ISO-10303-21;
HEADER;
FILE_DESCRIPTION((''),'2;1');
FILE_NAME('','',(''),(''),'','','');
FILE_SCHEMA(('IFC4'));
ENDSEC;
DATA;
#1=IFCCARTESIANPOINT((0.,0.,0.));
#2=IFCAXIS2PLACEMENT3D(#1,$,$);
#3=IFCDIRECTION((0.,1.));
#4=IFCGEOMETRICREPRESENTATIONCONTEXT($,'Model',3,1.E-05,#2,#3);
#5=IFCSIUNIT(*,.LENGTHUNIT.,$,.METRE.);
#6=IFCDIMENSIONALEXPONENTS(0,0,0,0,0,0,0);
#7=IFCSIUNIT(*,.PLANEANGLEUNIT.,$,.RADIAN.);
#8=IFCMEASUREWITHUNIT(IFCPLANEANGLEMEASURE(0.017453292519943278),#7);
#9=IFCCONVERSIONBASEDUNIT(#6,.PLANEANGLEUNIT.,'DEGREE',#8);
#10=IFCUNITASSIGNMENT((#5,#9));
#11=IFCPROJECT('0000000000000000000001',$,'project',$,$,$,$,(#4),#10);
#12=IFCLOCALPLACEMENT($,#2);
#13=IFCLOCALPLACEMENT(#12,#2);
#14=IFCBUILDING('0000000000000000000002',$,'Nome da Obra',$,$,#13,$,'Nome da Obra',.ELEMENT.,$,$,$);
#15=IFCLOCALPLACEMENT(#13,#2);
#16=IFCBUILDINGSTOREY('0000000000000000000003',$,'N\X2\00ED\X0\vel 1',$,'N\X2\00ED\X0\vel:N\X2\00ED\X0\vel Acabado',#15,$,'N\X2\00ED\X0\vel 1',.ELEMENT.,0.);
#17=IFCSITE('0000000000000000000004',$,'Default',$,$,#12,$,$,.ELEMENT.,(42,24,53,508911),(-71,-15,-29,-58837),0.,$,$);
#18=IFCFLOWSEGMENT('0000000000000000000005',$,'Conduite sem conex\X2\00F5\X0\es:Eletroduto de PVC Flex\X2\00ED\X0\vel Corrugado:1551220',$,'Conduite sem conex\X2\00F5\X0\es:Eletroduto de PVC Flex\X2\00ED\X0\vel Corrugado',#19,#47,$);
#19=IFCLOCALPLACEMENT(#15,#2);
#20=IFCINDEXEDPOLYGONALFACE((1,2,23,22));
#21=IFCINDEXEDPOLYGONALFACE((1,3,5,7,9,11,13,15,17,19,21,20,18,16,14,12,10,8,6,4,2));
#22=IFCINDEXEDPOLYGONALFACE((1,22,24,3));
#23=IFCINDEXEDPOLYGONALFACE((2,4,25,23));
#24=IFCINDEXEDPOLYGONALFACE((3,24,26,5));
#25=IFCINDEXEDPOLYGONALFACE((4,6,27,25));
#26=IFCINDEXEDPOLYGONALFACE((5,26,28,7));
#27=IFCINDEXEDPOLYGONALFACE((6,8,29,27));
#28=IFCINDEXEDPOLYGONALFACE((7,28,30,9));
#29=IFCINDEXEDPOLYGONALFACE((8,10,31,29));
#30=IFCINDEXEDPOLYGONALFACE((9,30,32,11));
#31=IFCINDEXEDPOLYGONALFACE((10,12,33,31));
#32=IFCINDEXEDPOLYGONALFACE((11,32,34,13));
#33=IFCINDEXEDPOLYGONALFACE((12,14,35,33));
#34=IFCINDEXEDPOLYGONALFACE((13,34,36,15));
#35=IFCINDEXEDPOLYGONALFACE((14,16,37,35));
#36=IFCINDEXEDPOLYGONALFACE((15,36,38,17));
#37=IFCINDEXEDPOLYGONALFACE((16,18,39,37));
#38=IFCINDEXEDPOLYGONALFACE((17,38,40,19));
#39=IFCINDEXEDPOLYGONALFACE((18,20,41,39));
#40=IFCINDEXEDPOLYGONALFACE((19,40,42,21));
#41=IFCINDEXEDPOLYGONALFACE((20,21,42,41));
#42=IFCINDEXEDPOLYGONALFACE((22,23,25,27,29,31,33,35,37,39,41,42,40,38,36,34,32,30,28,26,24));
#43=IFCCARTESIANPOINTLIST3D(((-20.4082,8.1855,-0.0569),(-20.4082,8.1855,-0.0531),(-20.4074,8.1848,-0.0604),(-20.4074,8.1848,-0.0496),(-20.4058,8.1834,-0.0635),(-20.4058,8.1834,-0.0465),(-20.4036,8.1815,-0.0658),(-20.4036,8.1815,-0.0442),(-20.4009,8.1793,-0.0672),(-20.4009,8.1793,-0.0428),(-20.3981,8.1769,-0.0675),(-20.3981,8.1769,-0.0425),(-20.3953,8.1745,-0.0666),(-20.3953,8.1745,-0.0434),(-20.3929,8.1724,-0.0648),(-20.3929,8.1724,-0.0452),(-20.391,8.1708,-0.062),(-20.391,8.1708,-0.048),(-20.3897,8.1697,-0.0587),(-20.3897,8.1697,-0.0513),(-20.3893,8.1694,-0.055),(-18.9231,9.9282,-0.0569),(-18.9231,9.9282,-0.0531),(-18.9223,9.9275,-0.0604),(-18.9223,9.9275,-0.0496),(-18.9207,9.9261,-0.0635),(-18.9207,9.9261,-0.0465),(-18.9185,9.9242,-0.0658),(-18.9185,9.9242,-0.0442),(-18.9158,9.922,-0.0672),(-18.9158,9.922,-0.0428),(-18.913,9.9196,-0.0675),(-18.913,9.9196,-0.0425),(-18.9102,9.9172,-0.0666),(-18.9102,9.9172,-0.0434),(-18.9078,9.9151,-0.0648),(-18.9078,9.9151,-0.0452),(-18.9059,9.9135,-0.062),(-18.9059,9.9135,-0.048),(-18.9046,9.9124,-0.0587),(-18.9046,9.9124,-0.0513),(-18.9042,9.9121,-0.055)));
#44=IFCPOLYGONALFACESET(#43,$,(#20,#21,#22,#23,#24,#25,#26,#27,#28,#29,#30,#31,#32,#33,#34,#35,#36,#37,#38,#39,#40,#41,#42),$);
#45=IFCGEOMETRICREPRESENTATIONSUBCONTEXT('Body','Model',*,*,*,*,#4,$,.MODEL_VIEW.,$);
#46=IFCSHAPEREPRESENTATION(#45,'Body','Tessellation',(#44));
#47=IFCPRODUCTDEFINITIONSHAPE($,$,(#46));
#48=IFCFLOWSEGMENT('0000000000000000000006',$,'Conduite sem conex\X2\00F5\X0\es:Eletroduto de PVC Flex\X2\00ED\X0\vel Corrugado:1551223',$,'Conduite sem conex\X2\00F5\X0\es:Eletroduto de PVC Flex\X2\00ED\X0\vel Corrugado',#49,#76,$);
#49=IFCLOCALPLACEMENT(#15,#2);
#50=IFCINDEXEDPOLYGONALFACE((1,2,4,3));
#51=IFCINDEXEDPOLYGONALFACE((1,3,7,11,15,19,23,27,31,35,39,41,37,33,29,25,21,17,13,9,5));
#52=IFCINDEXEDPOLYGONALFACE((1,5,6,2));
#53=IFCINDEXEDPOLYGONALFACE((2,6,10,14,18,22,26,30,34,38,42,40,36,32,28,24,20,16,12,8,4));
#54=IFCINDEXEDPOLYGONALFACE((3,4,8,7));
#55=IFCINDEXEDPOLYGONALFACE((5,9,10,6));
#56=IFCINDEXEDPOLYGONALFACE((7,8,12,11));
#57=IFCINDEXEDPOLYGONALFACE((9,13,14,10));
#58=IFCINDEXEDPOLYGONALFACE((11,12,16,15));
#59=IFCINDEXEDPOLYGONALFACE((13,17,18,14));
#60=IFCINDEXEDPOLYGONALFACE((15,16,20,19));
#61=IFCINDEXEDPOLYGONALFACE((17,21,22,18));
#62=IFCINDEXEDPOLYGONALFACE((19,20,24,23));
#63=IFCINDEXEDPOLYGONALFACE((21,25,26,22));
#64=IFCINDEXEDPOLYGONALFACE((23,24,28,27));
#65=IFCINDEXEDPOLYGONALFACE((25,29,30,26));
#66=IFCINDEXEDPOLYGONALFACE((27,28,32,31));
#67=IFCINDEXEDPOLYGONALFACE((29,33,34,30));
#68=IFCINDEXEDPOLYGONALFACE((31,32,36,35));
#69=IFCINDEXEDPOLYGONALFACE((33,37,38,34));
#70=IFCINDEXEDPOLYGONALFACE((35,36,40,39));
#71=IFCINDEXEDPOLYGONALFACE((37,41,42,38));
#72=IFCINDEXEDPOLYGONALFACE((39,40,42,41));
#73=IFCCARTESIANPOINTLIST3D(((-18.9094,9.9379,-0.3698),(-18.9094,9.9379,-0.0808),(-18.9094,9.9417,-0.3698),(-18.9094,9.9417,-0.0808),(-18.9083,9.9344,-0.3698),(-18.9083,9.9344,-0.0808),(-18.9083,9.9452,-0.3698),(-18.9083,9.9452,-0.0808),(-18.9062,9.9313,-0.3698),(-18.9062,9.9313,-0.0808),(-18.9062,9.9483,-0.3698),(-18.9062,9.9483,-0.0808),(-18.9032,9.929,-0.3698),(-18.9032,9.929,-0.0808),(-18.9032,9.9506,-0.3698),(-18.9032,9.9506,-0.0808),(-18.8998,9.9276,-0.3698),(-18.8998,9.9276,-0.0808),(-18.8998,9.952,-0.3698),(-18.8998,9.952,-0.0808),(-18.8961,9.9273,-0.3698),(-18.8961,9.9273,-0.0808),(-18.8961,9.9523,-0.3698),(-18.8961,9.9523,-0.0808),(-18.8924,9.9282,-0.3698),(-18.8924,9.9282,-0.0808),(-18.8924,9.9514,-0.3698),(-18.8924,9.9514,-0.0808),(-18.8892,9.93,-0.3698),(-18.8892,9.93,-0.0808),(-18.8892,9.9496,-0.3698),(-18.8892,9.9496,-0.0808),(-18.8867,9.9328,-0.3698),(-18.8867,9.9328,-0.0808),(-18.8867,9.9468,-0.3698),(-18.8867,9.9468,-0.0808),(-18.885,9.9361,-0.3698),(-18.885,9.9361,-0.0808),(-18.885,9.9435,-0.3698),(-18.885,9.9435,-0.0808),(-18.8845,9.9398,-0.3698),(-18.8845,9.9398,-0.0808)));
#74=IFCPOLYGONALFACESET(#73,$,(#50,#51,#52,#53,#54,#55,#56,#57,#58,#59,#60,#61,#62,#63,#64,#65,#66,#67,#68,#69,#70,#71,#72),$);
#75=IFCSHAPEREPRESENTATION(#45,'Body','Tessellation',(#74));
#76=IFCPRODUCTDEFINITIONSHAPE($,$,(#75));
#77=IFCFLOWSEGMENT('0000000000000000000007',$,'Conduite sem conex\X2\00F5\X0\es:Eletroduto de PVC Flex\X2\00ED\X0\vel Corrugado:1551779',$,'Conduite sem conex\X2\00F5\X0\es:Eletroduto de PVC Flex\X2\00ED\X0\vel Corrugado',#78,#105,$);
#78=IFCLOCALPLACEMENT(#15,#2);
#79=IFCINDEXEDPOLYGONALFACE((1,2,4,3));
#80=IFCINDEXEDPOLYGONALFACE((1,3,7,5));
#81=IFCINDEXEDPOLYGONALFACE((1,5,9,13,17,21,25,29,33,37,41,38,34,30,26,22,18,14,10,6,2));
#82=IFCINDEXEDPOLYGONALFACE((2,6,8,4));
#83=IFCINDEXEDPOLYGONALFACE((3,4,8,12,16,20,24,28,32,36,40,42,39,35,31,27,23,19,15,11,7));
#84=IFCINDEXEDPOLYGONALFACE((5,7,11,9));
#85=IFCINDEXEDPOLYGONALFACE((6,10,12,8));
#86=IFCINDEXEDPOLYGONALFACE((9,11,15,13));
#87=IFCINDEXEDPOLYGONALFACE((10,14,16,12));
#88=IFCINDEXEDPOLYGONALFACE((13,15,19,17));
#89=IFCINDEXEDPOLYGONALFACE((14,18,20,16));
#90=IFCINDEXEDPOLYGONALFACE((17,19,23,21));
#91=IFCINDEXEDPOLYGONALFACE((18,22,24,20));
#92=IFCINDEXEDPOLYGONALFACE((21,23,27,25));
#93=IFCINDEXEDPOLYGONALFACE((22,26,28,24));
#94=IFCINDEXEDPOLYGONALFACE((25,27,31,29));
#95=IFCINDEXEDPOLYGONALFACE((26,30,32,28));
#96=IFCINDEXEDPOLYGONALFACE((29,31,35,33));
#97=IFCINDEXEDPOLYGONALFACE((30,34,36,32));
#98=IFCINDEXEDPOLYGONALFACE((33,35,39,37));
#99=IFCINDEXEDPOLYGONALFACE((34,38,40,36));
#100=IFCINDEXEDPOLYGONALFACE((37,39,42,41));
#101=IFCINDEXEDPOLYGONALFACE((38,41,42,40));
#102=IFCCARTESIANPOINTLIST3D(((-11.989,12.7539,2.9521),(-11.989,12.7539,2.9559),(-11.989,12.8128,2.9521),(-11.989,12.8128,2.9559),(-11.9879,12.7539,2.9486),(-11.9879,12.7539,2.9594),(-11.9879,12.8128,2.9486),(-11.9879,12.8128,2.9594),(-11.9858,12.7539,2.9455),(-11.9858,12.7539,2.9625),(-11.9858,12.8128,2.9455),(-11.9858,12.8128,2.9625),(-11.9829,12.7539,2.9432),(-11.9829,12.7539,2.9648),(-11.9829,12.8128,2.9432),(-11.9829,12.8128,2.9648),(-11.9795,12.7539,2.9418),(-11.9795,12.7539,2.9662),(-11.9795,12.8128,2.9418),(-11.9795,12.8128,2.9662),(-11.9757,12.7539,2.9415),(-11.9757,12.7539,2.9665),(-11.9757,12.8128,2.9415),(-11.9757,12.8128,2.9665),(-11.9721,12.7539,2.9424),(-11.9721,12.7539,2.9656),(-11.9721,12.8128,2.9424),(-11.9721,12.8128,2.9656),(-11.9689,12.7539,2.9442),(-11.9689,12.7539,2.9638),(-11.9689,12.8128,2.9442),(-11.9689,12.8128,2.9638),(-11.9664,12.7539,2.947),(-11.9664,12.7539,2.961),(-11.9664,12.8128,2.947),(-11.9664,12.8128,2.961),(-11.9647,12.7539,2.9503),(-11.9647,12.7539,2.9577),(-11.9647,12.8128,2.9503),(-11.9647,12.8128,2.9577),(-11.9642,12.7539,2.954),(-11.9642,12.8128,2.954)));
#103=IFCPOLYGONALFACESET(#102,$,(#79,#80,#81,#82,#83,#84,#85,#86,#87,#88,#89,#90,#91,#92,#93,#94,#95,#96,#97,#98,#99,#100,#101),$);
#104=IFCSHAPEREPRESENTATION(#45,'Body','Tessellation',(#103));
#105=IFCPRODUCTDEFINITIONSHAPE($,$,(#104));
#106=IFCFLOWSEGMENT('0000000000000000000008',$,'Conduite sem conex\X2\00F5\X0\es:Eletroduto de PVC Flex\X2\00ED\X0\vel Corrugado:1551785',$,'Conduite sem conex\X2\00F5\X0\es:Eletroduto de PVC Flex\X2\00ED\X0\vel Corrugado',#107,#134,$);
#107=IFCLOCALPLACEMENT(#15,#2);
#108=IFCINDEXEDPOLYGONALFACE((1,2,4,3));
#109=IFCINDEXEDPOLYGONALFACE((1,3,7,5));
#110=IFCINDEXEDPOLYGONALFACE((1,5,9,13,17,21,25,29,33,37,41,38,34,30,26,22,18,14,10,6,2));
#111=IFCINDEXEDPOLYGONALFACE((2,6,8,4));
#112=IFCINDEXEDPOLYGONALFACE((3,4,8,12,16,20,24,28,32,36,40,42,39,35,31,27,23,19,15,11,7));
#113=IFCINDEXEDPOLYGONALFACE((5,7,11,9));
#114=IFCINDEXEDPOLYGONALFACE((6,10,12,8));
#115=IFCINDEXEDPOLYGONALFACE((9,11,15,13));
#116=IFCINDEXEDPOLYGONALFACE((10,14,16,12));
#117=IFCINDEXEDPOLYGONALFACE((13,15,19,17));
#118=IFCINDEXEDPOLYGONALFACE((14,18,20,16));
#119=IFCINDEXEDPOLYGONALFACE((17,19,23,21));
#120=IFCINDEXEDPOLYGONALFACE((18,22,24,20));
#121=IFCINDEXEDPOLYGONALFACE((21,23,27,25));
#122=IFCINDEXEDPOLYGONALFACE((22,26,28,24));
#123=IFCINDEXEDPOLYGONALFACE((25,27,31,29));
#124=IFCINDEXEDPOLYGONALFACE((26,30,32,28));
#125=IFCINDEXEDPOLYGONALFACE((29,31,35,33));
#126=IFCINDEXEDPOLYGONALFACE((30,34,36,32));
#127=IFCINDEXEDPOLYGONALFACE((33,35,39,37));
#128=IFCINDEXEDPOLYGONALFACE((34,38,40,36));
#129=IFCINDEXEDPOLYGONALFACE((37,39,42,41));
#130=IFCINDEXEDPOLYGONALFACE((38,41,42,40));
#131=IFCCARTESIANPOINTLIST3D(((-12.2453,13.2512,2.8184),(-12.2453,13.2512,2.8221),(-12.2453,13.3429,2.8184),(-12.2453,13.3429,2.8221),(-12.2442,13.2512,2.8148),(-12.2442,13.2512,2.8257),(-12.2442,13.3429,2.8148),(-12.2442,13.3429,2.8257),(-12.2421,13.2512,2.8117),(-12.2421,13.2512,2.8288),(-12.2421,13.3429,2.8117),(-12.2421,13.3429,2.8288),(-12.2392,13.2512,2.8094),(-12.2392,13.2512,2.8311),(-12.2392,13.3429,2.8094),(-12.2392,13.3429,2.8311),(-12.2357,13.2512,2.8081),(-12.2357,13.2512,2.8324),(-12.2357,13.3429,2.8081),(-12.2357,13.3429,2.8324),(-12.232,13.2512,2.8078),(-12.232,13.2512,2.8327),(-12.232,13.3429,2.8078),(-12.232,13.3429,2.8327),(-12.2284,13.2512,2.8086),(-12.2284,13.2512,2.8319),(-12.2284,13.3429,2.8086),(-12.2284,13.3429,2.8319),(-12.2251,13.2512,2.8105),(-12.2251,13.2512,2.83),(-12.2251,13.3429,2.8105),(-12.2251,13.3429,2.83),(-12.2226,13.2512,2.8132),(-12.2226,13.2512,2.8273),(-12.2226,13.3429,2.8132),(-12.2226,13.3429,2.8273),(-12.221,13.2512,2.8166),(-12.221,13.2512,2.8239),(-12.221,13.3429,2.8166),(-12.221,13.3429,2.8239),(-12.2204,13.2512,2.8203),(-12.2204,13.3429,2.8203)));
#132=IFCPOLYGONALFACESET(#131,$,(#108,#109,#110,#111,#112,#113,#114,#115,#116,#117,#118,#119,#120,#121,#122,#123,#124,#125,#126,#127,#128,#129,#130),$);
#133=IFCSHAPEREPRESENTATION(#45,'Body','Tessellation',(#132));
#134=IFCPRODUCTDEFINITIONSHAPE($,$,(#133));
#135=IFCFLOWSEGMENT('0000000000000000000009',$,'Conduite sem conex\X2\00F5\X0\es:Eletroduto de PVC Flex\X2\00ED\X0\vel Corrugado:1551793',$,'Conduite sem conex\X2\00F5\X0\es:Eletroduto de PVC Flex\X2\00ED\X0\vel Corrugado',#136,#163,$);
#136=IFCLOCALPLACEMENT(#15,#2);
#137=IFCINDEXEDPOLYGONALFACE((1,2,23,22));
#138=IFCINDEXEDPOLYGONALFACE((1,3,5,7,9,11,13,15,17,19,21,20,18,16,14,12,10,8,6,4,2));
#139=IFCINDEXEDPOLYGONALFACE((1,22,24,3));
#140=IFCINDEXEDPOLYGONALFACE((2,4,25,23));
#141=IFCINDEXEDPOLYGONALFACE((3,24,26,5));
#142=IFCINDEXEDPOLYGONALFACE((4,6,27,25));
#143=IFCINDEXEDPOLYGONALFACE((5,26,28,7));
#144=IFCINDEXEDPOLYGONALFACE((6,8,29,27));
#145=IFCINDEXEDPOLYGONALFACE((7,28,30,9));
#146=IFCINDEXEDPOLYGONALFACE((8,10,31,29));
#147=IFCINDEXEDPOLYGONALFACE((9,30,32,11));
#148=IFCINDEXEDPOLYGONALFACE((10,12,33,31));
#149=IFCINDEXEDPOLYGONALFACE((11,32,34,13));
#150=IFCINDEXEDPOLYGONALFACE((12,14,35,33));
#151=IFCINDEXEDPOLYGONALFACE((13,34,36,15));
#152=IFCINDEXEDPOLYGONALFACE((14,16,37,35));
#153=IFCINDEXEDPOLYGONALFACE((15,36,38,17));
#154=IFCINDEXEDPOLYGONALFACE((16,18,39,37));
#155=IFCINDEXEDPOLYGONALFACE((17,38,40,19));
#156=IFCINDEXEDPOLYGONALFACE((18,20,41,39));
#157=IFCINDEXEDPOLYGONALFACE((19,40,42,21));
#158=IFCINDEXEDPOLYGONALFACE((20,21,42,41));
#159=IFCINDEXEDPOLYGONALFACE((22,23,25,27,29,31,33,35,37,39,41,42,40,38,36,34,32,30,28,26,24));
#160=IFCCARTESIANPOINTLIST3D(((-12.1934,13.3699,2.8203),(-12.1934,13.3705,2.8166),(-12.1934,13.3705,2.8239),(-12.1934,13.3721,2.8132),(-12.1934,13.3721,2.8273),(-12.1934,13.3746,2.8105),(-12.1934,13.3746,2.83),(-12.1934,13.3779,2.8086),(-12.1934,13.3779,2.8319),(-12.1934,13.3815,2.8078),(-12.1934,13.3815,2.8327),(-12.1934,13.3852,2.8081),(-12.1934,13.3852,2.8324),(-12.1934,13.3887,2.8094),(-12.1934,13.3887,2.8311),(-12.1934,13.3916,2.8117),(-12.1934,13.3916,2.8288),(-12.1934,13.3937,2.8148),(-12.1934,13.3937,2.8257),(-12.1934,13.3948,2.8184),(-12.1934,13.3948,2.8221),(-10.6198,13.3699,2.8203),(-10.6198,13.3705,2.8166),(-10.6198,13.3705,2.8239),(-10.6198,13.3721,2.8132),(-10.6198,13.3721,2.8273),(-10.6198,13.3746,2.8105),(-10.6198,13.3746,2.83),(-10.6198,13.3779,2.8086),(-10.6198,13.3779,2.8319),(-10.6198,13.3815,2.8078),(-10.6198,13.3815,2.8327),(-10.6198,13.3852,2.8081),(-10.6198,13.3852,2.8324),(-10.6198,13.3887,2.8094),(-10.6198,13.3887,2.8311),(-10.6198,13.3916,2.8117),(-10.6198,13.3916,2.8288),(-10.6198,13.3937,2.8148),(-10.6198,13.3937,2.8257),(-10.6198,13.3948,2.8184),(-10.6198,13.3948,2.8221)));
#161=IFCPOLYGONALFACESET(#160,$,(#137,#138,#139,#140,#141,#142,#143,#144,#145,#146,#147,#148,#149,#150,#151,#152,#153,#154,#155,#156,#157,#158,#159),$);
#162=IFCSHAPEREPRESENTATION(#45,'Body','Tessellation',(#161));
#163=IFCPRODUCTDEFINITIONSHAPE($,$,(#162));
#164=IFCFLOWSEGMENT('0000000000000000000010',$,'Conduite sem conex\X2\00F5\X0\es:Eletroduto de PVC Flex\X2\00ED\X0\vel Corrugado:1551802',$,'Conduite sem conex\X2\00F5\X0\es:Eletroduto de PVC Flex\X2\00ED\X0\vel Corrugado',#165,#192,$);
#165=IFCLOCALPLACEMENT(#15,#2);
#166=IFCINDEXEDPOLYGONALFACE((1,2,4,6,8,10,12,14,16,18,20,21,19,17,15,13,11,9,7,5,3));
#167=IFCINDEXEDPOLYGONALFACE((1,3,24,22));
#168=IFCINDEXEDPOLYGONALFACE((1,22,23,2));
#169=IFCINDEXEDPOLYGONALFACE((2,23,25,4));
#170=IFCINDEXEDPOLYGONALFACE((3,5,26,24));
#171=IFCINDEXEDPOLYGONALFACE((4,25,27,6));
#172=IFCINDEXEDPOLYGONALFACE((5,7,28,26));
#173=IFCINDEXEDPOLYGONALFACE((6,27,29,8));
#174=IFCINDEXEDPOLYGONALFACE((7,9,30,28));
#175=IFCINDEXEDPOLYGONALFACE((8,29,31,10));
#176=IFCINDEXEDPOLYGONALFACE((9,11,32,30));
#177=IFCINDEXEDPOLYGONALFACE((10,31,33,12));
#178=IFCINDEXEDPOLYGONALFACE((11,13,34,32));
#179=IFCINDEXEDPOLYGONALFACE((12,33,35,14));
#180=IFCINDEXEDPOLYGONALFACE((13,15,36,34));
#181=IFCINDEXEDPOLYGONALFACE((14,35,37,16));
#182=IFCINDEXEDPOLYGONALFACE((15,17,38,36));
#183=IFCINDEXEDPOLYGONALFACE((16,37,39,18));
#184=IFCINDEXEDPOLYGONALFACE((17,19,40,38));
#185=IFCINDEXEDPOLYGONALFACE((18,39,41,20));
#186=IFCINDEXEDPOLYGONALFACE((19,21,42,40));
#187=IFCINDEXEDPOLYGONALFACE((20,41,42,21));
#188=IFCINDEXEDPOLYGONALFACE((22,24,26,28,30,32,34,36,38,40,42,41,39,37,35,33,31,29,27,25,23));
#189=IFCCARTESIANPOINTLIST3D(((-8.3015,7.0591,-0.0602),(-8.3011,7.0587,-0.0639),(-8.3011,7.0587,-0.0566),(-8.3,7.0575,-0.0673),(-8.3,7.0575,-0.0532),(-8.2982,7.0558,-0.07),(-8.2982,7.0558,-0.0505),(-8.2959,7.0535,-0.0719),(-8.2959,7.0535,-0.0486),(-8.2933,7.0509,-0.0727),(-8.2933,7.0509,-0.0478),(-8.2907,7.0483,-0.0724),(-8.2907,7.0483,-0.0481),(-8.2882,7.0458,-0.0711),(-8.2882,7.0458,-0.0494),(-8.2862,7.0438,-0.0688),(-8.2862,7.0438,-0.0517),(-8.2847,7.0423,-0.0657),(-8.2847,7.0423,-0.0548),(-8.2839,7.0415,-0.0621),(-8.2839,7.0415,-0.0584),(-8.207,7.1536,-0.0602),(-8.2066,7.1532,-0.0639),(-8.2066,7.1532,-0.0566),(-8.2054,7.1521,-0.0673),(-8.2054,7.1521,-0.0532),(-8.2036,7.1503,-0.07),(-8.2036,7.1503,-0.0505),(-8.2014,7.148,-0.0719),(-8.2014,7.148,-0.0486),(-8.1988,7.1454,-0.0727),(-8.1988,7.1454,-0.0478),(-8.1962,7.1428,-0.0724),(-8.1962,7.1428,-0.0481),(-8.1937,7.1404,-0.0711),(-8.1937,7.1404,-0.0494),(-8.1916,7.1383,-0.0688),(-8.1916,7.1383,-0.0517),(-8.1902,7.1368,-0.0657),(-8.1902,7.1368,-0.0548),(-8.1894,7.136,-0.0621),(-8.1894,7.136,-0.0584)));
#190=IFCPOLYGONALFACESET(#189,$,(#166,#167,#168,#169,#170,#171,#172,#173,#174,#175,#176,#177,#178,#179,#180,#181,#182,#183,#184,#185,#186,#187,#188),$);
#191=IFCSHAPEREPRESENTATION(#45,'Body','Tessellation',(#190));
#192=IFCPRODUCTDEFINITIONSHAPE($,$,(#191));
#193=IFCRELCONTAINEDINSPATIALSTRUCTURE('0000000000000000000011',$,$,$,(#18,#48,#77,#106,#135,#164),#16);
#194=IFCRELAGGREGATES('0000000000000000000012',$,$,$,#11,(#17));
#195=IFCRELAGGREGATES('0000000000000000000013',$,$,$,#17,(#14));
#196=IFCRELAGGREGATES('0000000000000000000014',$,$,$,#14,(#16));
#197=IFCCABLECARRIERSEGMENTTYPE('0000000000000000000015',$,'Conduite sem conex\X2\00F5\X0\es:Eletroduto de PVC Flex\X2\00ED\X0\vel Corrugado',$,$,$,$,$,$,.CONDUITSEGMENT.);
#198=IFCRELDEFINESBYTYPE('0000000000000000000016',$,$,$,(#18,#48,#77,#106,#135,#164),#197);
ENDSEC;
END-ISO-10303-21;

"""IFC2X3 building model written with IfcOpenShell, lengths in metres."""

from ifc_helpers import new_model, entity, si_unit, converted_unit, direction, frame, frame_2d, origin, origin_2d_with_axis, place, context, subcontext, project, spatial, circle, extrude, type_object, element, save


model = new_model("IFC2X3")

# Units and contexts
model_context = context("Model", 3, precision=1e-05, world=origin(), true_north=direction((0.0, 1.0)))
body_context = subcontext(model_context, "Body", "Model", "MODEL_VIEW")
ifc_project = project(units=[si_unit("LENGTHUNIT", "METRE"), converted_unit("PLANEANGLEUNIT", "DEGREE", entity("IfcPlaneAngleMeasure", 0.017453292519943278), si_unit("PLANEANGLEUNIT", "RADIAN"), dimensions=[0, 0, 0, 0, 0, 0, 0])], contexts=[model_context])

# Site, building, storey
site_placement = place(None, origin())
site = spatial("IfcSite", under=ifc_project, at=site_placement, Name="Default", CompositionType="ELEMENT", RefLatitude=(42, 24, 53, 508911), RefLongitude=(-71, -15, -29, -58837), RefElevation=0.0)
building_placement = place(site_placement, origin())
building = spatial("IfcBuilding", under=site, at=building_placement, Name="Nome da Obra", LongName="Nome da Obra", CompositionType="ELEMENT")
storey_placement = place(building_placement, origin())
storey = spatial("IfcBuildingStorey", under=building, at=storey_placement, Name="Nível 1", ObjectType="Nível:Nível Acabado", LongName="Nível 1", CompositionType="ELEMENT", Elevation=0.0)

# Flow segments
cable_carrier_segment_type = type_object("IfcCableCarrierSegmentType", Name="Conduite sem conexões:Eletroduto de PVC Flexível Corrugado", PredefinedType="CONDUITSEGMENT")
flow_segment_1_placement = place(storey_placement, origin())
element("IfcFlowSegment", 1, at=flow_segment_1_placement, inside=storey, type_object=cable_carrier_segment_type, Name="Conduite sem conexões:Eletroduto de PVC Flexível Corrugado:1551220", ObjectType="Conduite sem conexões:Eletroduto de PVC Flexível Corrugado", context=body_context, shape_type="SweptSolid", body=[
    extrude(circle(Radius=0.0125, at=frame_2d((0.0, 0.0), x_axis=(1.0, 0.0))), frame((-20.3988, 8.1775, -0.055), z_axis=(0.648615, 0.761116, 0.0), x_axis=(0.761116, -0.648615, 0.0)), (0.0, 0.0, 1.0), 2.2896),
])
flow_segment_2_placement = place(storey_placement, origin())
element("IfcFlowSegment", 2, at=flow_segment_2_placement, inside=storey, type_object=cable_carrier_segment_type, Name="Conduite sem conexões:Eletroduto de PVC Flexível Corrugado:1551223", ObjectType="Conduite sem conexões:Eletroduto de PVC Flexível Corrugado", context=body_context, shape_type="SweptSolid", body=[
    extrude(circle(Radius=0.0125, at=frame_2d((0.0, 0.0), x_axis=(1.0, 0.0))), frame((-18.897, 9.9398, -0.3698)), (0.0, 0.0, 1.0), 0.289),
])
flow_segment_3_placement = place(storey_placement, origin())
element("IfcFlowSegment", 3, at=flow_segment_3_placement, inside=storey, type_object=cable_carrier_segment_type, Name="Conduite sem conexões:Eletroduto de PVC Flexível Corrugado:1551779", ObjectType="Conduite sem conexões:Eletroduto de PVC Flexível Corrugado", context=body_context, shape_type="SweptSolid", body=[
    extrude(circle(Radius=0.0125, at=frame_2d((0.0, 0.0), x_axis=(1.0, 0.0))), frame((-11.9767, 12.7539, 2.954), z_axis=(0.0, 1.0, 0.0), x_axis=(1.0, 0.0, 0.0)), (0.0, 0.0, 1.0), 0.0589),
])
flow_segment_4_placement = place(storey_placement, origin())
element("IfcFlowSegment", 4, at=flow_segment_4_placement, inside=storey, type_object=cable_carrier_segment_type, Name="Conduite sem conexões:Eletroduto de PVC Flexível Corrugado:1551785", ObjectType="Conduite sem conexões:Eletroduto de PVC Flexível Corrugado", context=body_context, shape_type="SweptSolid", body=[
    extrude(circle(Radius=0.0125, at=origin_2d_with_axis()), frame((-12.2329, 13.2512, 2.8203), z_axis=(0.0, 1.0, 0.0), x_axis=(1.0, 0.0, 0.0)), (0.0, 0.0, 1.0), 0.0917),
])
flow_segment_5_placement = place(storey_placement, origin())
element("IfcFlowSegment", 5, at=flow_segment_5_placement, inside=storey, type_object=cable_carrier_segment_type, Name="Conduite sem conexões:Eletroduto de PVC Flexível Corrugado:1551793", ObjectType="Conduite sem conexões:Eletroduto de PVC Flexível Corrugado", context=body_context, shape_type="SweptSolid", body=[
    extrude(circle(Radius=0.0125, at=origin_2d_with_axis()), frame((-12.1934, 13.3824, 2.8203), z_axis=(1.0, 0.0, 0.0), x_axis=(0.0, -1.0, 0.0)), (0.0, 0.0, 1.0), 1.5736),
])
flow_segment_6_placement = place(storey_placement, origin())
element("IfcFlowSegment", 6, at=flow_segment_6_placement, inside=storey, type_object=cable_carrier_segment_type, Name="Conduite sem conexões:Eletroduto de PVC Flexível Corrugado:1551802", ObjectType="Conduite sem conexões:Eletroduto de PVC Flexível Corrugado", context=body_context, shape_type="SweptSolid", body=[
    extrude(circle(Radius=0.0125, at=frame_2d((0.0, 0.0), x_axis=(1.0, 0.0))), frame((-8.2927, 7.0502, -0.0602), z_axis=(0.707107, 0.707107, 0.0), x_axis=(-0.707107, 0.707107, 0.0)), (0.0, 0.0, 1.0), 0.1337),
])

save(model, "model.ifc")
